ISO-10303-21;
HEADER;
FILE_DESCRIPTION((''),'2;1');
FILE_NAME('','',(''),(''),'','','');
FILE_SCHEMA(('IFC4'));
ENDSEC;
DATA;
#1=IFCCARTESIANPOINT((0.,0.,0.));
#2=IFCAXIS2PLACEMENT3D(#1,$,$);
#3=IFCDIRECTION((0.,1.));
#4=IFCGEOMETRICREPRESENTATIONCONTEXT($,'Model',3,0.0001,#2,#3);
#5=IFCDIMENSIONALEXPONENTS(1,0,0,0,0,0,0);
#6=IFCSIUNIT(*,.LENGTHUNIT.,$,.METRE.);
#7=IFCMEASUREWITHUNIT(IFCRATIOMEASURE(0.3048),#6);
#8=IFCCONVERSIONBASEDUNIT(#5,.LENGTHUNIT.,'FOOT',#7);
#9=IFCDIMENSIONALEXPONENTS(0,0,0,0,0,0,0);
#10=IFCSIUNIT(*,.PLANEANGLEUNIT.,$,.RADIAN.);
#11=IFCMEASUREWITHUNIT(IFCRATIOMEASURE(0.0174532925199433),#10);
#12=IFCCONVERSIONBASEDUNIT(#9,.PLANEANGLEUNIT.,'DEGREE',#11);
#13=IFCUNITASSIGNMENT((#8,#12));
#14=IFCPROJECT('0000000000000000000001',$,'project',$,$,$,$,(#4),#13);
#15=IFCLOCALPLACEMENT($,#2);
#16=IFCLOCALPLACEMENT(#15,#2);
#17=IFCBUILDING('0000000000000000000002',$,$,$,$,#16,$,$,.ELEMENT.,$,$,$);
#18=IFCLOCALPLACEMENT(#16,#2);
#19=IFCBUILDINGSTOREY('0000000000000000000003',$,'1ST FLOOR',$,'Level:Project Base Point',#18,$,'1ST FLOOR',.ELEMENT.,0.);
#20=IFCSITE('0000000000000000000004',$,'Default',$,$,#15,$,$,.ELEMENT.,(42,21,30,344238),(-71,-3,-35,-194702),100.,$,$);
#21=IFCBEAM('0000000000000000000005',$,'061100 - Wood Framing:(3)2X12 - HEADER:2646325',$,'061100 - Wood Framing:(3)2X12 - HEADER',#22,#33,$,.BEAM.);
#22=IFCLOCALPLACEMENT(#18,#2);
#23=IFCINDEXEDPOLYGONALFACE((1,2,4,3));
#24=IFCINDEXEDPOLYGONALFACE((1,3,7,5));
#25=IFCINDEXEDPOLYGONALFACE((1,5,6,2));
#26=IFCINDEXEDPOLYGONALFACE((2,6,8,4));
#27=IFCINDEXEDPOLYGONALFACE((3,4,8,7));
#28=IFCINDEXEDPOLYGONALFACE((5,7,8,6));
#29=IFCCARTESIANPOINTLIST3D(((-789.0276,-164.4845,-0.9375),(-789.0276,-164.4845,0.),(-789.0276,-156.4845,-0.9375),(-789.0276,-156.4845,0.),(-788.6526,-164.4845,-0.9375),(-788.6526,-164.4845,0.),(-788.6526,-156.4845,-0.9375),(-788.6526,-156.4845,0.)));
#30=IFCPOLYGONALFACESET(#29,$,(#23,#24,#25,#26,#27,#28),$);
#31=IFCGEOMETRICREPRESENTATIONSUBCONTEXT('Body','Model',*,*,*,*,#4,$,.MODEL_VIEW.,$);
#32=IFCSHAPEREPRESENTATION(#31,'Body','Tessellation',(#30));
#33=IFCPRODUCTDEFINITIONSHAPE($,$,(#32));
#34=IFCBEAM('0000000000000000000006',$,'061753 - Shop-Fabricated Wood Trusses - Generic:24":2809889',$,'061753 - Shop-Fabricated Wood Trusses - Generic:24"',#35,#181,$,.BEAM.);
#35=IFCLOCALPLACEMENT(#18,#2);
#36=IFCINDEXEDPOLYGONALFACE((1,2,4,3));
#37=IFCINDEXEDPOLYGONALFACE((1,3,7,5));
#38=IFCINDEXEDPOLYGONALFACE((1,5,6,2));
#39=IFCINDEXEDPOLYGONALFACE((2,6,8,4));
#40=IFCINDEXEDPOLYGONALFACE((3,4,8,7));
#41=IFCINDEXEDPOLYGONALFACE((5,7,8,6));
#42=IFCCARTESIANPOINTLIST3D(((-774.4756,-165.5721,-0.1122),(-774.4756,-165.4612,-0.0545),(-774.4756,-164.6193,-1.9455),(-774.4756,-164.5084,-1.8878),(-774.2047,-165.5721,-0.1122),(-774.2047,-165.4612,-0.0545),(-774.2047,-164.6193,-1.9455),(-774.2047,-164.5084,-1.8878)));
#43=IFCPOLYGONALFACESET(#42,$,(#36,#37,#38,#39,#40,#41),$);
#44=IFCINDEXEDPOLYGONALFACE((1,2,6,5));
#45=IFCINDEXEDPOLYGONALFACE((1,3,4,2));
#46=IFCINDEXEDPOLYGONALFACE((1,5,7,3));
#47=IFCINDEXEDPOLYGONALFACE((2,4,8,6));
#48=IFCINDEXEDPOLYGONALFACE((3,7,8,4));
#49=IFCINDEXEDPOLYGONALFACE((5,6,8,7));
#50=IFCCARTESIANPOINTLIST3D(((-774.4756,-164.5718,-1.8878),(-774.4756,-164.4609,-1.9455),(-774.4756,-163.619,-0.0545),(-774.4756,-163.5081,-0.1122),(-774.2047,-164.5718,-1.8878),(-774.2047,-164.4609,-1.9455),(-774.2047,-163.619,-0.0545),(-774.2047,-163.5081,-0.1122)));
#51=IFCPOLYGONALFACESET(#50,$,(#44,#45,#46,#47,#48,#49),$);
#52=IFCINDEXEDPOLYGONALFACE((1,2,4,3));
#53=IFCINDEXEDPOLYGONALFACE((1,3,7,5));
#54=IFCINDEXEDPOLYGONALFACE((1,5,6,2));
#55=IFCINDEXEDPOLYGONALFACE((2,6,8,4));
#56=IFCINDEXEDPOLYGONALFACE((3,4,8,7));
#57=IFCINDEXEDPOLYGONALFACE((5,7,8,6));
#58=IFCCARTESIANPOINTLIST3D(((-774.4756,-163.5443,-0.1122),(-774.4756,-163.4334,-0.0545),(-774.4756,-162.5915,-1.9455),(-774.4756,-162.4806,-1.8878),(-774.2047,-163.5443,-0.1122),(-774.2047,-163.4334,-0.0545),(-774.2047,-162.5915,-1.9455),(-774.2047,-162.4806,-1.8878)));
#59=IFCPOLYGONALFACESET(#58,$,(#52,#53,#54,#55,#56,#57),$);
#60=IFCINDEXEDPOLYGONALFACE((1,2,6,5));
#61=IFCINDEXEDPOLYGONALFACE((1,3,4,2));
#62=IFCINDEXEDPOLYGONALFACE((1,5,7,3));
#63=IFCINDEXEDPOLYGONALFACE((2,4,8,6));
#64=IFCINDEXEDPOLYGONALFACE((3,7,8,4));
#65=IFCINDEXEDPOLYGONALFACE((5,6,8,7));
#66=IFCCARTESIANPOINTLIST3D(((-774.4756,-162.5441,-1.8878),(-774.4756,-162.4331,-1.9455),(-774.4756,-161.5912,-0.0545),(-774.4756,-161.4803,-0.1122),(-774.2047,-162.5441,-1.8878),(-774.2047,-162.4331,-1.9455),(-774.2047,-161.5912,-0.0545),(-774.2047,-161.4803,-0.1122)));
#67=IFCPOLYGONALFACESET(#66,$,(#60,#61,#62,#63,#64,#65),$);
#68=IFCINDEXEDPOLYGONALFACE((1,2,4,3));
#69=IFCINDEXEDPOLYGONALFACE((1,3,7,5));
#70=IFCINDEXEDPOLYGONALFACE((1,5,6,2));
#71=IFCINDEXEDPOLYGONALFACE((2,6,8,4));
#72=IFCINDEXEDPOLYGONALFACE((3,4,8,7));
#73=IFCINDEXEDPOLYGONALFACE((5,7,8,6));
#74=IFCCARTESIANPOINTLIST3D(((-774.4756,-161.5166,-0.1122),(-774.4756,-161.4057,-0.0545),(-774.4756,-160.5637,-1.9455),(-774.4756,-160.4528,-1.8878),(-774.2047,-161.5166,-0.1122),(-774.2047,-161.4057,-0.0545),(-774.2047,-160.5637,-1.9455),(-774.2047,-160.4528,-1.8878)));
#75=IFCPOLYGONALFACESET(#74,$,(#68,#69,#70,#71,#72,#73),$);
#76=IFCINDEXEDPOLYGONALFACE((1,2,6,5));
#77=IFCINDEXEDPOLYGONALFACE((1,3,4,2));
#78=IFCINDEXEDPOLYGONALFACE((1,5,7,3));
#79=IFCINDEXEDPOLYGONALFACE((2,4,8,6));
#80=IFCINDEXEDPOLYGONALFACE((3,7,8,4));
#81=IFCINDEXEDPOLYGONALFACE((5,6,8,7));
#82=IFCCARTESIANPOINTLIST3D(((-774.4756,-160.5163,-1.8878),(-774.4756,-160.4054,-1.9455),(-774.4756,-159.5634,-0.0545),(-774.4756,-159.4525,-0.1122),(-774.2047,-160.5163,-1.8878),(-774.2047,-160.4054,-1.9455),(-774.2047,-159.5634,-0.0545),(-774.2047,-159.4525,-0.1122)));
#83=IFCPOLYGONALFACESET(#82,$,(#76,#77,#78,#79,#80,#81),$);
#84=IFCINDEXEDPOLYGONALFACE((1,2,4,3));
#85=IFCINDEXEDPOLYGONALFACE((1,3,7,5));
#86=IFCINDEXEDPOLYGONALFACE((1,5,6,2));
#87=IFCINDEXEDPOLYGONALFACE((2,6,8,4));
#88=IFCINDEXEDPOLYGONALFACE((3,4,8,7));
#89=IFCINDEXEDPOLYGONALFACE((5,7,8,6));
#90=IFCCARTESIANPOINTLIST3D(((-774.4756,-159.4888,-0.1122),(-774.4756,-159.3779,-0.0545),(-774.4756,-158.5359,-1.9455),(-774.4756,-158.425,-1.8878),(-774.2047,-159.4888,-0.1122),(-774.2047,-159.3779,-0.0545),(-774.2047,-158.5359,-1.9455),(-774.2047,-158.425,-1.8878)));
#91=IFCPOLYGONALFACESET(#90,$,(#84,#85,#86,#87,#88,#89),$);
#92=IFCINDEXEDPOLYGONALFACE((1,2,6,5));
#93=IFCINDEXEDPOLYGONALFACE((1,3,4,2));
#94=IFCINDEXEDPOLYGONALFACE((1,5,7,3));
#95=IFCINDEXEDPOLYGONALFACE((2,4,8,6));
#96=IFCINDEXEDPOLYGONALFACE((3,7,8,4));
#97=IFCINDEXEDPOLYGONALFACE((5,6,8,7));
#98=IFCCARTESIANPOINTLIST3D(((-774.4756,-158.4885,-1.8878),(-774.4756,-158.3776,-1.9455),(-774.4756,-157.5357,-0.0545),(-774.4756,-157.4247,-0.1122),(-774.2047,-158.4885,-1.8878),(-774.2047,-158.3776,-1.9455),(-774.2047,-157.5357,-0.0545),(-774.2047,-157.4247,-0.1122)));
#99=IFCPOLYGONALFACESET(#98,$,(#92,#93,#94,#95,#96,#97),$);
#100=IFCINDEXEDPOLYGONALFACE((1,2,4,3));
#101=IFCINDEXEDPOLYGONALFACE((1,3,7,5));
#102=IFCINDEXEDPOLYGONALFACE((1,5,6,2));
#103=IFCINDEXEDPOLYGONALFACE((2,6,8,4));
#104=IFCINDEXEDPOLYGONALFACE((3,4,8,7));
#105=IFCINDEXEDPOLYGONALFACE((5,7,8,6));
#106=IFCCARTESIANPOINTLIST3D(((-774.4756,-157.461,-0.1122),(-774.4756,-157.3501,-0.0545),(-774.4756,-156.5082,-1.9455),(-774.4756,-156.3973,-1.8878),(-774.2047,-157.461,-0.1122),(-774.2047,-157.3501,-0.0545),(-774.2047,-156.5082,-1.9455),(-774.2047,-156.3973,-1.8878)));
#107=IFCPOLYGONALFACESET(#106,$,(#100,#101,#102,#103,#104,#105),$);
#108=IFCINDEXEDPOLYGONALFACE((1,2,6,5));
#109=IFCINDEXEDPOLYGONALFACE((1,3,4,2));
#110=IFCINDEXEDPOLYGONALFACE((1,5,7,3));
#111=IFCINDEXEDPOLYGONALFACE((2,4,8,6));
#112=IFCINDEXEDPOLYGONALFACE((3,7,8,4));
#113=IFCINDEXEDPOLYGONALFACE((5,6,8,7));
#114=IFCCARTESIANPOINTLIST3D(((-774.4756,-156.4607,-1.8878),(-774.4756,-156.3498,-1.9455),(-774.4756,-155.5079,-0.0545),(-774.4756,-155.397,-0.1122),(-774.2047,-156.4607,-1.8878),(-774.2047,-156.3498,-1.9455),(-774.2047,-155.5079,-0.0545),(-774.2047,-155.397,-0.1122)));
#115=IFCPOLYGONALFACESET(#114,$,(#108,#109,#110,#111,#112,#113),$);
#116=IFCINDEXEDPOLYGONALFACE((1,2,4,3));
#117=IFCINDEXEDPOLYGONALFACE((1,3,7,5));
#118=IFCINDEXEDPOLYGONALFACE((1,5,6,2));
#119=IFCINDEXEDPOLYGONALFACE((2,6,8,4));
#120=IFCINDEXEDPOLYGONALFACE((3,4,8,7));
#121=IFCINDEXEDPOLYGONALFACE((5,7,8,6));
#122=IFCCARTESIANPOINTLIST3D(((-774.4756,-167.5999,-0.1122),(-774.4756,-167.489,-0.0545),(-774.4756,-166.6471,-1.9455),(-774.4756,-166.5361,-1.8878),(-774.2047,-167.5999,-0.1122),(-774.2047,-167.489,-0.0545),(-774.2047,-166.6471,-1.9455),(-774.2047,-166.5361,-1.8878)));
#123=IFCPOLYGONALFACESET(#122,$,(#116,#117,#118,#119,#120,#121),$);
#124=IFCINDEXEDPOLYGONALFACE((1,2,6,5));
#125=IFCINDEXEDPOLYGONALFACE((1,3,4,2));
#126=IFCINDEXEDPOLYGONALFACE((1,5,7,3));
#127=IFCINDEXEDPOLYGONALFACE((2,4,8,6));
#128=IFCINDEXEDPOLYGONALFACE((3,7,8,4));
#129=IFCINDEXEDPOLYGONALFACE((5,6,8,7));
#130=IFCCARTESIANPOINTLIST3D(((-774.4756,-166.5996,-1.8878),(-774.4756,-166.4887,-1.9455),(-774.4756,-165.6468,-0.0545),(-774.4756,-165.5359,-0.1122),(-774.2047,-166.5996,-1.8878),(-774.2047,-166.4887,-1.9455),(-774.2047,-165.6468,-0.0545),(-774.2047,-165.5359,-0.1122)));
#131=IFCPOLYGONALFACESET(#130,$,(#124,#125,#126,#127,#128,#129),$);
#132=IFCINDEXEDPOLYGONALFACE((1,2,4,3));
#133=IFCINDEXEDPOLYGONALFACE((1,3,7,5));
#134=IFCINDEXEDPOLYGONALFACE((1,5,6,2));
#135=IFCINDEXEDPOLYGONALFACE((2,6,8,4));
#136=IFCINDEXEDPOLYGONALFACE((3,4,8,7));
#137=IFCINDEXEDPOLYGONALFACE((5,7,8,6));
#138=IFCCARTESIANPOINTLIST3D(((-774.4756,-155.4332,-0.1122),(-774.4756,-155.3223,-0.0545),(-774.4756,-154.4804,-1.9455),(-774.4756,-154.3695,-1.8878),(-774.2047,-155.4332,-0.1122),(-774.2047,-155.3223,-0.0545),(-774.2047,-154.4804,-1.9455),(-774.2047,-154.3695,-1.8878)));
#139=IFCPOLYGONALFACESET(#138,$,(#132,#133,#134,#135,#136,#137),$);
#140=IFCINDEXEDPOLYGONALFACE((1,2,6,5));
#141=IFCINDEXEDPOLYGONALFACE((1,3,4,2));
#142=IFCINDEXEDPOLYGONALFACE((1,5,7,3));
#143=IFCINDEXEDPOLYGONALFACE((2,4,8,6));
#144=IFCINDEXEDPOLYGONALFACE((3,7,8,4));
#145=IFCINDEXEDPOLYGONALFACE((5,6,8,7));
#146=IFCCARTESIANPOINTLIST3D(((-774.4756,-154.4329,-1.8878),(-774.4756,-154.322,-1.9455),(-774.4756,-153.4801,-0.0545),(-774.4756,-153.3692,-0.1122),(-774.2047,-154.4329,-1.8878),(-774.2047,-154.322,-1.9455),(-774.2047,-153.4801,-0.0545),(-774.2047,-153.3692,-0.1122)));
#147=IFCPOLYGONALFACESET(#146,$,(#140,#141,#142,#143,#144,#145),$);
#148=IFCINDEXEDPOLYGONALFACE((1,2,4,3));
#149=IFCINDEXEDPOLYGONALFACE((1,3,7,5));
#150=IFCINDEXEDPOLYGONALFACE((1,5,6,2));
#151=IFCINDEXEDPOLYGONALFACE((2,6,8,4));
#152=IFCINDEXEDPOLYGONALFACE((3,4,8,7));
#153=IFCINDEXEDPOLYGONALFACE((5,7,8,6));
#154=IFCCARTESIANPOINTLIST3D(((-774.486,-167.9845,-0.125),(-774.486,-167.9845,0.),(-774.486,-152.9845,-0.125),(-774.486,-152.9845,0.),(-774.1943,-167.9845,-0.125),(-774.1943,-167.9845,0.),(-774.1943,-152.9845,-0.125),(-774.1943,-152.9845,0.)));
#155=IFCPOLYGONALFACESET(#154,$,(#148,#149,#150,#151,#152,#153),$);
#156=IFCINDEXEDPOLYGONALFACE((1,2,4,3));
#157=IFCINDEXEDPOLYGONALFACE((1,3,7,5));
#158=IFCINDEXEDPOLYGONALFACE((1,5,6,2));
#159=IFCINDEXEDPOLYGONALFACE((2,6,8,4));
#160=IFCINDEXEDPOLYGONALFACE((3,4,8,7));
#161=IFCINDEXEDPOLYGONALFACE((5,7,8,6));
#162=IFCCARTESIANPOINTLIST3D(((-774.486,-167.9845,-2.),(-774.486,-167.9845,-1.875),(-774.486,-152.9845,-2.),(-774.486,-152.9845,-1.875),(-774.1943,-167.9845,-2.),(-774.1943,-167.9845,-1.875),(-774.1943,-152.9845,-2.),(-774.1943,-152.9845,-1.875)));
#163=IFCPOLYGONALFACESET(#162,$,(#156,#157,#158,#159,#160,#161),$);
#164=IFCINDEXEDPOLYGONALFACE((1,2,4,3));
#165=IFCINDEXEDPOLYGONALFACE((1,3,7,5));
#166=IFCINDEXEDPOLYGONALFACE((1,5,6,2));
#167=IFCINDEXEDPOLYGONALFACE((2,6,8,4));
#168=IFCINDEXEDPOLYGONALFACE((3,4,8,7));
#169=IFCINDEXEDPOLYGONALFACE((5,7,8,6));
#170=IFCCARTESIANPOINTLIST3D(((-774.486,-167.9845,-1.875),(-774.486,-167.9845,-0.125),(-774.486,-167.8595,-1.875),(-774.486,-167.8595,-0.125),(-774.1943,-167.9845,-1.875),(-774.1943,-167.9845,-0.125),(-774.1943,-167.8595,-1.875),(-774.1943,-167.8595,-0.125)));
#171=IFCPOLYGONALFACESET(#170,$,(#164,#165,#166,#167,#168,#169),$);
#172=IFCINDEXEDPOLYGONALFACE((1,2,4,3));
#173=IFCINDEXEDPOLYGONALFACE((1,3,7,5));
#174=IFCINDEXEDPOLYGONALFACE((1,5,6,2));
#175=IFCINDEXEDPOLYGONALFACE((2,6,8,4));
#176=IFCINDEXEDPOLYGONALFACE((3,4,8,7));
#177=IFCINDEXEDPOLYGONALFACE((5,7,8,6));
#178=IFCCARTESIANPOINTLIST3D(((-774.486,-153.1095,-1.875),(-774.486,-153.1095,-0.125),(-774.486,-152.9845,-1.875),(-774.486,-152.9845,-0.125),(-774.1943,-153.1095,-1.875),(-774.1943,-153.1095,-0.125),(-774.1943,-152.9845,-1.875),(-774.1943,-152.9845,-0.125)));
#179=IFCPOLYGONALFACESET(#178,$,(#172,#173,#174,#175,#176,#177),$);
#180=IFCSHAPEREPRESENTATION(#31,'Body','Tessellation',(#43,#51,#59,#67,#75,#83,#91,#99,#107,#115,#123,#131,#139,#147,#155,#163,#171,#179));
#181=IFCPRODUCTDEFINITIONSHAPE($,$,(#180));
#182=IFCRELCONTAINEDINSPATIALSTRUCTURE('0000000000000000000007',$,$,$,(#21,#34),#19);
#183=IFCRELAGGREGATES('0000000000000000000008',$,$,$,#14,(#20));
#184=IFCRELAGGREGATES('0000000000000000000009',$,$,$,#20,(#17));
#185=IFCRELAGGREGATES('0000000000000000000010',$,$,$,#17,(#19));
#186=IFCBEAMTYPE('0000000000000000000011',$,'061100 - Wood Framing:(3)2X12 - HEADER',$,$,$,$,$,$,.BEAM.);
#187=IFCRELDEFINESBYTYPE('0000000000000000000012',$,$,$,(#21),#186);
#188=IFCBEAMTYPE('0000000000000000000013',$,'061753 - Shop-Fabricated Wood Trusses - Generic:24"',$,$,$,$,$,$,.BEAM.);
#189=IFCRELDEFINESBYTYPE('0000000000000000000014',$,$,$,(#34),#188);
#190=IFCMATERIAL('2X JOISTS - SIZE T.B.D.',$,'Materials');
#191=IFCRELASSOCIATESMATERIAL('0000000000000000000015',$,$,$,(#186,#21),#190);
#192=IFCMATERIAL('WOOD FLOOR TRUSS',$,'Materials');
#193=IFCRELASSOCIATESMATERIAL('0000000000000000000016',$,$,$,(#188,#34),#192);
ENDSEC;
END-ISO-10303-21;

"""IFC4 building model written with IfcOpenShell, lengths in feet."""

from ifc_helpers import new_model, entity, si_unit, converted_unit, direction, frame, frame_2d, origin, origin_2d_with_axis, place, context, subcontext, project, spatial, rectangle, extrude, source, transform, mapped, material, material_profile, profile_set, profile_usage, type_object, type_shapes, element, save


model = new_model("IFC4")

# Units and contexts
model_context = context("Model", 3, precision=0.0001, world=origin(), true_north=direction((0.0, 1.0)))
body_context = subcontext(model_context, "Body", "Model", "MODEL_VIEW")
ifc_project = project(units=[converted_unit("LENGTHUNIT", "FOOT", entity("IfcRatioMeasure", 0.3048), si_unit("LENGTHUNIT", "METRE"), dimensions=[1, 0, 0, 0, 0, 0, 0]), converted_unit("PLANEANGLEUNIT", "DEGREE", entity("IfcRatioMeasure", 0.0174532925199433), si_unit("PLANEANGLEUNIT", "RADIAN"), dimensions=[0, 0, 0, 0, 0, 0, 0])], contexts=[model_context])

# Site, building, storey
site_placement = place(None, origin())
site = spatial("IfcSite", under=ifc_project, at=site_placement, Name="Default", CompositionType="ELEMENT", RefLatitude=(42, 21, 30, 344238), RefLongitude=(-71, -3, -35, -194702), RefElevation=100.0)
building_placement = place(site_placement, origin())
building = spatial("IfcBuilding", under=site, at=building_placement, CompositionType="ELEMENT")
storey_placement = place(building_placement, origin())
storey = spatial("IfcBuildingStorey", under=building, at=storey_placement, Name="1ST FLOOR", ObjectType="Level:Project Base Point", LongName="1ST FLOOR", CompositionType="ELEMENT", Elevation=0.0)

# Beams
ifc_material_1 = material(Name="2X JOISTS - SIZE T.B.D.", Category="Materials")
ifc_material_profile_1 = material_profile(ifc_material_1, rectangle(XDim=0.9375, YDim=0.375, at=origin_2d_with_axis()), Name="(3)2X12 - HEADER")
ifc_profile_set_1 = profile_set([ifc_material_profile_1], Name="(3)2X12 - HEADER")
ifc_profile_usage_1 = profile_usage(ifc_profile_set_1, cardinal=8)
beam_type_1 = type_object("IfcBeamType", Name="061100 - Wood Framing:(3)2X12 - HEADER", PredefinedType="BEAM", material=ifc_profile_set_1)
shared_shape_1 = source(origin(), body_context, "Body", "SweptSolid", [
    extrude(rectangle(XDim=0.9375, YDim=0.375, at=origin_2d_with_axis()), frame((-4.0, 0.0, 0.0), z_axis=(1.0, 0.0, 0.0), x_axis=(0.0, 0.0, -1.0)), (0.0, 0.0, 1.0), 8.0),
])
type_shapes(beam_type_1, [shared_shape_1])
beam_1_placement = place(storey_placement, frame((-788.8401, -160.4845, -0.4687), z_axis=(0.0, 0.0, 1.0), x_axis=(0.0, -1.0, 0.0)))
element("IfcBeam", 1, at=beam_1_placement, inside=storey, type_object=beam_type_1, material=ifc_profile_usage_1, Name="061100 - Wood Framing:(3)2X12 - HEADER:2646325", ObjectType="061100 - Wood Framing:(3)2X12 - HEADER", PredefinedType="BEAM", context=body_context, shape_type="MappedRepresentation", body=[
    mapped(shared_shape_1, transform((0.0, 0.0, 0.0), scale=1.0)),
])
ifc_material_2 = material(Name="WOOD FLOOR TRUSS", Category="Materials")
ifc_material_profile_2 = material_profile(ifc_material_2, rectangle(XDim=2.0662, YDim=0.125, at=origin_2d_with_axis()), Name="24\"")
ifc_material_profile_3 = material_profile(ifc_material_2, rectangle(XDim=2.0662, YDim=0.125, at=frame_2d((0.0, 0.0), x_axis=(1.0, 0.0))), Name="24\"")
ifc_material_profile_4 = material_profile(ifc_material_2, rectangle(XDim=2.0662, YDim=0.125, at=frame_2d((0.0, 0.0), x_axis=(1.0, 0.0))), Name="24\"")
ifc_material_profile_5 = material_profile(ifc_material_2, rectangle(XDim=2.0662, YDim=0.125, at=origin_2d_with_axis()), Name="24\"")
ifc_material_profile_6 = material_profile(ifc_material_2, rectangle(XDim=2.0662, YDim=0.125, at=origin_2d_with_axis()), Name="24\"")
ifc_material_profile_7 = material_profile(ifc_material_2, rectangle(XDim=2.0662, YDim=0.125, at=frame_2d((0.0, 0.0), x_axis=(1.0, 0.0))), Name="24\"")
ifc_material_profile_8 = material_profile(ifc_material_2, rectangle(XDim=2.0662, YDim=0.125, at=origin_2d_with_axis()), Name="24\"")
ifc_material_profile_9 = material_profile(ifc_material_2, rectangle(XDim=2.0662, YDim=0.125, at=frame_2d((0.0, 0.0), x_axis=(1.0, 0.0))), Name="24\"")
ifc_material_profile_10 = material_profile(ifc_material_2, rectangle(XDim=2.0662, YDim=0.125, at=origin_2d_with_axis()), Name="24\"")
ifc_material_profile_11 = material_profile(ifc_material_2, rectangle(XDim=2.0662, YDim=0.125, at=frame_2d((0.0, 0.0), x_axis=(1.0, 0.0))), Name="24\"")
ifc_material_profile_12 = material_profile(ifc_material_2, rectangle(XDim=2.0662, YDim=0.125, at=origin_2d_with_axis()), Name="24\"")
ifc_material_profile_13 = material_profile(ifc_material_2, rectangle(XDim=2.0662, YDim=0.125, at=frame_2d((0.0, 0.0), x_axis=(1.0, 0.0))), Name="24\"")
ifc_material_profile_14 = material_profile(ifc_material_2, rectangle(XDim=2.0662, YDim=0.125, at=origin_2d_with_axis()), Name="24\"")
ifc_material_profile_15 = material_profile(ifc_material_2, rectangle(XDim=2.0662, YDim=0.125, at=frame_2d((0.0, 0.0), x_axis=(1.0, 0.0))), Name="24\"")
ifc_material_profile_16 = material_profile(ifc_material_2, rectangle(XDim=0.125, YDim=0.2917, at=origin_2d_with_axis()), Name="24\"")
ifc_material_profile_17 = material_profile(ifc_material_2, rectangle(XDim=0.125, YDim=0.2917, at=origin_2d_with_axis()), Name="24\"")
ifc_material_profile_18 = material_profile(ifc_material_2, rectangle(XDim=1.75, YDim=0.2917, at=origin_2d_with_axis()), Name="24\"")
ifc_material_profile_19 = material_profile(ifc_material_2, rectangle(XDim=1.75, YDim=0.2917, at=origin_2d_with_axis()), Name="24\"")
ifc_profile_set_2 = profile_set([ifc_material_profile_2, ifc_material_profile_3, ifc_material_profile_4, ifc_material_profile_5, ifc_material_profile_6, ifc_material_profile_7, ifc_material_profile_8, ifc_material_profile_9, ifc_material_profile_10, ifc_material_profile_11, ifc_material_profile_12, ifc_material_profile_13, ifc_material_profile_14, ifc_material_profile_15, ifc_material_profile_16, ifc_material_profile_17, ifc_material_profile_18, ifc_material_profile_19], Name="24\"")
ifc_profile_usage_2 = profile_usage(ifc_profile_set_2, cardinal=8)
beam_type_2 = type_object("IfcBeamType", Name="061753 - Shop-Fabricated Wood Trusses - Generic:24\"", PredefinedType="BEAM", material=ifc_profile_set_2)
shared_shape_2 = source(origin(), body_context, "Body", "SweptSolid", [
    extrude(rectangle(XDim=2.0662, YDim=0.125, at=origin_2d_with_axis()), frame((4.5557, -0.1354, 0.0), z_axis=(0.0, 1.0, 0.0), x_axis=(0.461164, 0.0, 0.887315)), (0.0, 0.0, 1.0), 0.2708),
    extrude(rectangle(XDim=2.0662, YDim=0.125, at=frame_2d((0.0, 0.0), x_axis=(1.0, 0.0))), frame((3.5554, -0.1354, 0.0), z_axis=(0.0, 1.0, 0.0), x_axis=(0.461164, 0.0, -0.887315)), (0.0, 0.0, 1.0), 0.2708),
    extrude(rectangle(XDim=2.0662, YDim=0.125, at=frame_2d((0.0, 0.0), x_axis=(1.0, 0.0))), frame((2.5279, -0.1354, 0.0), z_axis=(0.0, 1.0, 0.0), x_axis=(0.461164, 0.0, 0.887315)), (0.0, 0.0, 1.0), 0.2708),
    extrude(rectangle(XDim=2.0662, YDim=0.125, at=origin_2d_with_axis()), frame((1.5276, -0.1354, 0.0), z_axis=(0.0, 1.0, 0.0), x_axis=(0.461164, 0.0, -0.887315)), (0.0, 0.0, 1.0), 0.2708),
    extrude(rectangle(XDim=2.0662, YDim=0.125, at=origin_2d_with_axis()), frame((0.5001, -0.1354, 0.0), z_axis=(0.0, 1.0, 0.0), x_axis=(0.461164, 0.0, 0.887315)), (0.0, 0.0, 1.0), 0.2708),
    extrude(rectangle(XDim=2.0662, YDim=0.125, at=frame_2d((0.0, 0.0), x_axis=(1.0, 0.0))), frame((-0.5001, -0.1354, 0.0), z_axis=(0.0, 1.0, 0.0), x_axis=(0.461164, 0.0, -0.887315)), (0.0, 0.0, 1.0), 0.2708),
    extrude(rectangle(XDim=2.0662, YDim=0.125, at=origin_2d_with_axis()), frame((-1.5276, -0.1354, 0.0), z_axis=(0.0, 1.0, 0.0), x_axis=(0.461164, 0.0, 0.887315)), (0.0, 0.0, 1.0), 0.2708),
    extrude(rectangle(XDim=2.0662, YDim=0.125, at=frame_2d((0.0, 0.0), x_axis=(1.0, 0.0))), frame((-2.5279, -0.1354, 0.0), z_axis=(0.0, 1.0, 0.0), x_axis=(0.461164, 0.0, -0.887315)), (0.0, 0.0, 1.0), 0.2708),
    extrude(rectangle(XDim=2.0662, YDim=0.125, at=origin_2d_with_axis()), frame((-3.5554, -0.1354, 0.0), z_axis=(0.0, 1.0, 0.0), x_axis=(0.461164, 0.0, 0.887315)), (0.0, 0.0, 1.0), 0.2708),
    extrude(rectangle(XDim=2.0662, YDim=0.125, at=frame_2d((0.0, 0.0), x_axis=(1.0, 0.0))), frame((-4.5557, -0.1354, 0.0), z_axis=(0.0, 1.0, 0.0), x_axis=(0.461164, 0.0, -0.887315)), (0.0, 0.0, 1.0), 0.2708),
    extrude(rectangle(XDim=2.0662, YDim=0.125, at=origin_2d_with_axis()), frame((6.5835, -0.1354, 0.0), z_axis=(0.0, 1.0, 0.0), x_axis=(0.461164, 0.0, 0.887315)), (0.0, 0.0, 1.0), 0.2708),
    extrude(rectangle(XDim=2.0662, YDim=0.125, at=frame_2d((0.0, 0.0), x_axis=(1.0, 0.0))), frame((5.5832, -0.1354, 0.0), z_axis=(0.0, 1.0, 0.0), x_axis=(0.461164, 0.0, -0.887315)), (0.0, 0.0, 1.0), 0.2708),
    extrude(rectangle(XDim=2.0662, YDim=0.125, at=origin_2d_with_axis()), frame((-5.5832, -0.1354, 0.0), z_axis=(0.0, 1.0, 0.0), x_axis=(0.461164, 0.0, 0.887315)), (0.0, 0.0, 1.0), 0.2708),
    extrude(rectangle(XDim=2.0662, YDim=0.125, at=frame_2d((0.0, 0.0), x_axis=(1.0, 0.0))), frame((-6.5835, -0.1354, 0.0), z_axis=(0.0, 1.0, 0.0), x_axis=(0.461164, 0.0, -0.887315)), (0.0, 0.0, 1.0), 0.2708),
    extrude(rectangle(XDim=0.125, YDim=0.2917, at=origin_2d_with_axis()), frame((-7.5, 0.0, 0.9375), z_axis=(1.0, 0.0, 0.0), x_axis=(0.0, 0.0, -1.0)), (0.0, 0.0, 1.0), 15.0),
    extrude(rectangle(XDim=0.125, YDim=0.2917, at=origin_2d_with_axis()), frame((-7.5, 0.0, -0.9375), z_axis=(1.0, 0.0, 0.0), x_axis=(0.0, 0.0, -1.0)), (0.0, 0.0, 1.0), 15.0),
    extrude(rectangle(XDim=1.75, YDim=0.2917, at=origin_2d_with_axis()), frame((7.375, 0.0, 0.0), z_axis=(1.0, 0.0, 0.0), x_axis=(0.0, 0.0, -1.0)), (0.0, 0.0, 1.0), 0.125),
    extrude(rectangle(XDim=1.75, YDim=0.2917, at=origin_2d_with_axis()), frame((-7.5, 0.0, 0.0), z_axis=(1.0, 0.0, 0.0), x_axis=(0.0, 0.0, -1.0)), (0.0, 0.0, 1.0), 0.125),
])
type_shapes(beam_type_2, [shared_shape_2])
beam_2_placement = place(storey_placement, frame((-774.3401, -160.4845, -1.0), z_axis=(0.0, 0.0, 1.0), x_axis=(0.0, -1.0, 0.0)))
element("IfcBeam", 2, at=beam_2_placement, inside=storey, type_object=beam_type_2, material=ifc_profile_usage_2, Name="061753 - Shop-Fabricated Wood Trusses - Generic:24\":2809889", ObjectType="061753 - Shop-Fabricated Wood Trusses - Generic:24\"", PredefinedType="BEAM", context=body_context, shape_type="MappedRepresentation", body=[
    mapped(shared_shape_2, transform((0.0, 0.0, 0.0), scale=1.0)),
])

save(model, "model.ifc")
